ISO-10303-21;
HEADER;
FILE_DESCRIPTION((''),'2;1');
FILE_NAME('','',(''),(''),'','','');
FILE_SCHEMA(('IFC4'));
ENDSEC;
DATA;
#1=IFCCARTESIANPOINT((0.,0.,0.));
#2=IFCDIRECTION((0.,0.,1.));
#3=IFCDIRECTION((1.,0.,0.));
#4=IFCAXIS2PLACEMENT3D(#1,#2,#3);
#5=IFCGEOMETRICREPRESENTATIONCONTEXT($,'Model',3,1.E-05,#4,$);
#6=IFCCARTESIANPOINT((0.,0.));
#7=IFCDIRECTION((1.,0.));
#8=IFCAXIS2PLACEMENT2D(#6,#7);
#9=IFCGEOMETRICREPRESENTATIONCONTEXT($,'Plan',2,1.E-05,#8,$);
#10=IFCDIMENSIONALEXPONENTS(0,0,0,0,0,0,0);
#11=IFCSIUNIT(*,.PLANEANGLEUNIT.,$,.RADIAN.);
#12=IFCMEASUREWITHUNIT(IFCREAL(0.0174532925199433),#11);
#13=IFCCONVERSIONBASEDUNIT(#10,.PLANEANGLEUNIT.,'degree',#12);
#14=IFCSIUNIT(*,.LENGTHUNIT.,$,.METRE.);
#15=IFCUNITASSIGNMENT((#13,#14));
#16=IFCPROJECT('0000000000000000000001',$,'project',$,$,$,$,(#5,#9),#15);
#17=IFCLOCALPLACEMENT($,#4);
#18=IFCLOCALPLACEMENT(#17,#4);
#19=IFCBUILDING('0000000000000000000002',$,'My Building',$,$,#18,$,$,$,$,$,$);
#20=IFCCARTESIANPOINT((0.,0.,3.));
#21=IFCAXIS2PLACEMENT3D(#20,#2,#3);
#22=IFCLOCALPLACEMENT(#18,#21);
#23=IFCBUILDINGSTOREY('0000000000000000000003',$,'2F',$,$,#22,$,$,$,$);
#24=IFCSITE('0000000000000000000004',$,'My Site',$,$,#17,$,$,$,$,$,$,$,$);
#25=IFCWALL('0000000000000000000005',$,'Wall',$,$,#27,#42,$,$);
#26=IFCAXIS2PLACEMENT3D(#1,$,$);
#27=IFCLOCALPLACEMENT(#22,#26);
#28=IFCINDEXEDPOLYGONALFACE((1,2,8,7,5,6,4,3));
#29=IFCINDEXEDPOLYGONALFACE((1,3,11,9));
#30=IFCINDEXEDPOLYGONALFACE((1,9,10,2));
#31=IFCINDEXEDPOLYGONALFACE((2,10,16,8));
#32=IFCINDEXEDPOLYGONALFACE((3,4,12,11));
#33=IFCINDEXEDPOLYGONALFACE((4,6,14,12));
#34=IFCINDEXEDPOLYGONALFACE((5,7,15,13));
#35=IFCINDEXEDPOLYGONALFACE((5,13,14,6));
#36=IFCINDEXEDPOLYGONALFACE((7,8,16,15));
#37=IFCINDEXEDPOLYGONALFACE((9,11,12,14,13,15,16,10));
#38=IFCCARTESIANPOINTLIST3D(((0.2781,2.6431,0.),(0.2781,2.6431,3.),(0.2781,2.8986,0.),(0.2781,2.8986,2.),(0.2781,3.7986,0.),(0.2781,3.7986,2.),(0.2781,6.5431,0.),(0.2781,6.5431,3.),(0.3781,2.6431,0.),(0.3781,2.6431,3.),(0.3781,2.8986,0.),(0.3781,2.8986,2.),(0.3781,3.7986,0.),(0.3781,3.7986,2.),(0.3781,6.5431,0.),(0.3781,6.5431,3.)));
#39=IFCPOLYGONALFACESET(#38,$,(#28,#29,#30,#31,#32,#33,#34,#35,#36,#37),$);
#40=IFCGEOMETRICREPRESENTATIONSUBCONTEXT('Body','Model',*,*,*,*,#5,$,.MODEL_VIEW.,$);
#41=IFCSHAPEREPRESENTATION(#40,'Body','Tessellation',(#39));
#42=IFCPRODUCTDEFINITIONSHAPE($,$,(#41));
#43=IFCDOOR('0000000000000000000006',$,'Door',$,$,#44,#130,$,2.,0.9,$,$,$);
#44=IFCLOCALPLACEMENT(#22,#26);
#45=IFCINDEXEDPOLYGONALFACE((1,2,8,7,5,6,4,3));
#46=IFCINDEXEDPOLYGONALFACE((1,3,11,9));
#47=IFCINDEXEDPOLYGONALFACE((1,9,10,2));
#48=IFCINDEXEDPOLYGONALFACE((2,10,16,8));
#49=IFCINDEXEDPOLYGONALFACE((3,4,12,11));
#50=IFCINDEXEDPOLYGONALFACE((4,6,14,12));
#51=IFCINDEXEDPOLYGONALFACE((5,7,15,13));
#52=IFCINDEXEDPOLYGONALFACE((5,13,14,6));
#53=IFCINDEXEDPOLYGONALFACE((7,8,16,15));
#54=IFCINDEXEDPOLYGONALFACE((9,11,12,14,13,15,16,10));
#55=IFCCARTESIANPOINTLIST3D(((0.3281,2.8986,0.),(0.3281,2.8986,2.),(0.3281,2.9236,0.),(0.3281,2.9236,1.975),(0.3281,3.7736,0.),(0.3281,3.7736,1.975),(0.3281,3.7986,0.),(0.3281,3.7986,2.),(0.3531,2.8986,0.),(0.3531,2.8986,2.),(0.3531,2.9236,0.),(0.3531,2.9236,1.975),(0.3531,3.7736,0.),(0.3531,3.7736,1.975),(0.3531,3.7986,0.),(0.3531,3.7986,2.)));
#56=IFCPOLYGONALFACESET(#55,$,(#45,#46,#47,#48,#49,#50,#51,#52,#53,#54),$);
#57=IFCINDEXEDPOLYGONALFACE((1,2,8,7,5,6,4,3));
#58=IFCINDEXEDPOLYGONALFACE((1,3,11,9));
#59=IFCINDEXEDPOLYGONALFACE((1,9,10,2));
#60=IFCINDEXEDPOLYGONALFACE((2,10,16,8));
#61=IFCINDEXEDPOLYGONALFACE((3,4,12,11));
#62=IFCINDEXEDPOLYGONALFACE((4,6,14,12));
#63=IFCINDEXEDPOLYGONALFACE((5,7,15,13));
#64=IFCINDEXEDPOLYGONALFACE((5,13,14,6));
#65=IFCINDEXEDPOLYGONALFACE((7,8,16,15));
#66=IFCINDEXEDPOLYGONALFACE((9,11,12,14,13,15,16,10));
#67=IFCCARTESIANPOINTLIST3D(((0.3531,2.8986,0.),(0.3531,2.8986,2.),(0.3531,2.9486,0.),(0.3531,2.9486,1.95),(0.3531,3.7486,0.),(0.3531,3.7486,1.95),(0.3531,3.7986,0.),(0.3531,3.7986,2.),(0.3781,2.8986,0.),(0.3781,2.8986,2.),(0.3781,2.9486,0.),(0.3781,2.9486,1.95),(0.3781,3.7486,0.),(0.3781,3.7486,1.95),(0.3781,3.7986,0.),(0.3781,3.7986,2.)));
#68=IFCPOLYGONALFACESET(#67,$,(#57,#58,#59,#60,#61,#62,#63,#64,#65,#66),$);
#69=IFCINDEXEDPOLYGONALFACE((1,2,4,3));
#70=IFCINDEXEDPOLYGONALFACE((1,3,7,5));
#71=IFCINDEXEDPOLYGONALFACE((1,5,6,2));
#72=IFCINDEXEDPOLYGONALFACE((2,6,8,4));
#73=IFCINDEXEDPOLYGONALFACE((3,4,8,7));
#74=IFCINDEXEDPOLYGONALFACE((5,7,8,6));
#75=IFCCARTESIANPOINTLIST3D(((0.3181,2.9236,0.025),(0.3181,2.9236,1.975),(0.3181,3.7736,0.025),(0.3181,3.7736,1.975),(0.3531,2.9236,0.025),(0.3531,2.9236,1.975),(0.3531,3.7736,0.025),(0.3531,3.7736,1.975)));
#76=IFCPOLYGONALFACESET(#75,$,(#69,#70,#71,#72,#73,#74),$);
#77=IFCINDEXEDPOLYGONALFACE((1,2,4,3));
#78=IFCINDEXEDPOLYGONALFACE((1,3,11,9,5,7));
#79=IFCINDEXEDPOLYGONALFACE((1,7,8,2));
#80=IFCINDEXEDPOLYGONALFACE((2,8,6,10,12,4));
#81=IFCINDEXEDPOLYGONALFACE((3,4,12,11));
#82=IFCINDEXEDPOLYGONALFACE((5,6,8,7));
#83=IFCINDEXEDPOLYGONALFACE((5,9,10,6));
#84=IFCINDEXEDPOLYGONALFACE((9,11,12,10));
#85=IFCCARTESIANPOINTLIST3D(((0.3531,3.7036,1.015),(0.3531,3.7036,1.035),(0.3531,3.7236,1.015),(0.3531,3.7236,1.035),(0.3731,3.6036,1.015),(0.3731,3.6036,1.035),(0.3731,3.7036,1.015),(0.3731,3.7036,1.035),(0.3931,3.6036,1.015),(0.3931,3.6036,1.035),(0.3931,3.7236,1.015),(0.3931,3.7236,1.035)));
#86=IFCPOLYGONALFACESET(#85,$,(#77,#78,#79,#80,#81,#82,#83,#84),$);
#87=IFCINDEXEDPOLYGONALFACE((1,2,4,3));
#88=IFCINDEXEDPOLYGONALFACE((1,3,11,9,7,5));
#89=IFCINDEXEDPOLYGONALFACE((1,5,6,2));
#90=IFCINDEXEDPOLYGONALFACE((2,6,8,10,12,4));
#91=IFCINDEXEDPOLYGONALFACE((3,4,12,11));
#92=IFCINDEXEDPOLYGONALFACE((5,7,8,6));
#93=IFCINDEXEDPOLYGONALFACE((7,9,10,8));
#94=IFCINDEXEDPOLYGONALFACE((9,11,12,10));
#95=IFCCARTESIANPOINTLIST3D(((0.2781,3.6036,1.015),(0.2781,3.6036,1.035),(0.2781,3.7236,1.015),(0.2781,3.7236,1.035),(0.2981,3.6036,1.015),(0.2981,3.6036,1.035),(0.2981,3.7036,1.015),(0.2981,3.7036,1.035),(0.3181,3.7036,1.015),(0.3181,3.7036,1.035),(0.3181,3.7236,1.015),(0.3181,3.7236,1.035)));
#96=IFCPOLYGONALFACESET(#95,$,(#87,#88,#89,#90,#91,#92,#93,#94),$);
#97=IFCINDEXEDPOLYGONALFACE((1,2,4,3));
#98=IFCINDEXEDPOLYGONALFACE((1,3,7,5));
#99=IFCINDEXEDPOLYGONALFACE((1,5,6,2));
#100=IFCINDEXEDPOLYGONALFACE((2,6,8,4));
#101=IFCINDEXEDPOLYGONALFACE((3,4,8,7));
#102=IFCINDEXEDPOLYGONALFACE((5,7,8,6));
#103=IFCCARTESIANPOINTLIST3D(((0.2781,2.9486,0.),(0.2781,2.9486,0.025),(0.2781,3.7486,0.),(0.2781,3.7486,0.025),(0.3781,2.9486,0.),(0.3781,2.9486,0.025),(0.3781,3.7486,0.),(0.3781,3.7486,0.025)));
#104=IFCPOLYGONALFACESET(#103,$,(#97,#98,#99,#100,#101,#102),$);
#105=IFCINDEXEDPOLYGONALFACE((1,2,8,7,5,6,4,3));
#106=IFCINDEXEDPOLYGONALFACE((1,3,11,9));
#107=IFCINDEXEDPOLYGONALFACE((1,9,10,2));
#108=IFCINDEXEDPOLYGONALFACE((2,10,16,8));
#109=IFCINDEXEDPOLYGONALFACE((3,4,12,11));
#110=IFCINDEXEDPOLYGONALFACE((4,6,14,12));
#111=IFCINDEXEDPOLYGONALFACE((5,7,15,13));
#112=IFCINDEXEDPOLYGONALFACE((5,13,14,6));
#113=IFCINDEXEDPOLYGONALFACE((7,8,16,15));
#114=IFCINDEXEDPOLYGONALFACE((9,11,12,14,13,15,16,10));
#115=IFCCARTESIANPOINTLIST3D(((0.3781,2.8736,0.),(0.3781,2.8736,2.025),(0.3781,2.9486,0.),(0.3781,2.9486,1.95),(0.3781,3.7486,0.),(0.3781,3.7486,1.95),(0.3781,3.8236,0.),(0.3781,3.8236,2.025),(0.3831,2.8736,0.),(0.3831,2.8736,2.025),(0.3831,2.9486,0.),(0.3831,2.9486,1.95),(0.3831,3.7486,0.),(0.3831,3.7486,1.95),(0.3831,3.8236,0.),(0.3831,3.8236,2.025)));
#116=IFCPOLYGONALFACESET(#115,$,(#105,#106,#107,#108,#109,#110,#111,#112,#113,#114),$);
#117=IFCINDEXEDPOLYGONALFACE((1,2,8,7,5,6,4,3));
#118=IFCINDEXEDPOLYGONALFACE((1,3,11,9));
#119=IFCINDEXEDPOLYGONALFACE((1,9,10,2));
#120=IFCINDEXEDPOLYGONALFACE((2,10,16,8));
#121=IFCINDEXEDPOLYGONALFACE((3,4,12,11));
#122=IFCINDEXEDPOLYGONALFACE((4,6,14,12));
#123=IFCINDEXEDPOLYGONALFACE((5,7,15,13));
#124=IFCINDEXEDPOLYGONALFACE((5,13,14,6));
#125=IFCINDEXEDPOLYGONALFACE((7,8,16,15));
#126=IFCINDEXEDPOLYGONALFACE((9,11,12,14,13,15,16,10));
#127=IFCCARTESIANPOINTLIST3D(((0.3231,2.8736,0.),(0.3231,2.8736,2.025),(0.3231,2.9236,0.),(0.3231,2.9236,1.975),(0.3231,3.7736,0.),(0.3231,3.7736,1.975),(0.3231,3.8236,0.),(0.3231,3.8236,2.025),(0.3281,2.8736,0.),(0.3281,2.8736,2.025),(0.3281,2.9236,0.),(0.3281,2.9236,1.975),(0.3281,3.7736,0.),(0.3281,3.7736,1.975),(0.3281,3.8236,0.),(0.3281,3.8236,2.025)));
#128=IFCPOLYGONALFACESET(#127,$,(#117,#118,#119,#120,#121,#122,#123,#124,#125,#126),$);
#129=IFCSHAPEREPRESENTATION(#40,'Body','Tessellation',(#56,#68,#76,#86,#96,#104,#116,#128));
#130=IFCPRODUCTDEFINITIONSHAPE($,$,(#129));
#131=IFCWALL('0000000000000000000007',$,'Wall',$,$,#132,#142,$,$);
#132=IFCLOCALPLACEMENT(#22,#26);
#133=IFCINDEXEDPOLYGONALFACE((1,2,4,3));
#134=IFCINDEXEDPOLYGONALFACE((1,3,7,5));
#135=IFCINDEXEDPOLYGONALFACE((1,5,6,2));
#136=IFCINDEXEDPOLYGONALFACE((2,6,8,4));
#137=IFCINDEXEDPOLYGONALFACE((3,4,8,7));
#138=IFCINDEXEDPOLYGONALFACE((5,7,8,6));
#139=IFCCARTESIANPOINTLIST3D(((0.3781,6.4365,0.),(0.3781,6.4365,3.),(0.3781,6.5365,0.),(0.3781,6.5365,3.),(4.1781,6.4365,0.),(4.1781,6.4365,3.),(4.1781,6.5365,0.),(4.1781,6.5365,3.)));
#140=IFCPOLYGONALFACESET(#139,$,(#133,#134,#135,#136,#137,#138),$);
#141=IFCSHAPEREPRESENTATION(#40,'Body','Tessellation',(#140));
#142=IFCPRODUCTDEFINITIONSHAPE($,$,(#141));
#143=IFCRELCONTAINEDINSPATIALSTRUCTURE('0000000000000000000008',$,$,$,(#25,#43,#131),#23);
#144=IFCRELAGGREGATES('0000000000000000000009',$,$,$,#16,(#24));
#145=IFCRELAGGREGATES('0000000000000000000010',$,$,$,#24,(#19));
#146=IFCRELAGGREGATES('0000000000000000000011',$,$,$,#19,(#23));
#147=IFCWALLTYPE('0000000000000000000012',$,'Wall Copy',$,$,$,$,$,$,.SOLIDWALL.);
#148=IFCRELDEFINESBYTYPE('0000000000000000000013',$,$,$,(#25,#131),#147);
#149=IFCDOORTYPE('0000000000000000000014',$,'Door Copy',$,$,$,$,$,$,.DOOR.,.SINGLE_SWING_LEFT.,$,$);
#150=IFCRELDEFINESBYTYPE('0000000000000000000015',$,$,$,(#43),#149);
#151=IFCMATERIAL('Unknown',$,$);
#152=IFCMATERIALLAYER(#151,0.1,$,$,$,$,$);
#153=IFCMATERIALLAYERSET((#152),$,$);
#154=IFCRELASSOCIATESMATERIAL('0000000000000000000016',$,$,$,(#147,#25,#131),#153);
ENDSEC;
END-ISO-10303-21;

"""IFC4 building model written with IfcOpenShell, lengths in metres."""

from ifc_helpers import new_model, entity, si_unit, converted_unit, frame, origin_with_axes, origin_2d_with_axis, place, context, subcontext, project, spatial, line, indexed_curve, outline, extrude, shape, source, transform, mapped, material, layer, layer_set, layer_usage, type_object, type_shapes, element, fill, save


model = new_model("IFC4")

# Units and contexts
model_context = context("Model", 3, precision=1e-05, world=origin_with_axes())
plan_context = context("Plan", 2, precision=1e-05, world=origin_2d_with_axis())
body_context_1 = subcontext(model_context, "Body", "Model", "MODEL_VIEW")
body_context_2 = subcontext(plan_context, "Body", "Plan", "PLAN_VIEW")
ifc_project = project(units=[converted_unit("PLANEANGLEUNIT", "degree", entity("IfcReal", 0.0174532925199433), si_unit("PLANEANGLEUNIT", "RADIAN"), dimensions=[0, 0, 0, 0, 0, 0, 0]), si_unit("LENGTHUNIT", "METRE")], contexts=[model_context, plan_context])

# Site, building, storey
site_placement = place(None, origin_with_axes())
site = spatial("IfcSite", under=ifc_project, at=site_placement, Name="My Site")
building_placement = place(site_placement, origin_with_axes())
building = spatial("IfcBuilding", under=site, at=building_placement, Name="My Building")
storey_placement = place(building_placement, frame((0.0, 0.0, 3.0), z_axis=(0.0, 0.0, 1.0), x_axis=(1.0, 0.0, 0.0)))
storey = spatial("IfcBuildingStorey", under=building, at=storey_placement, Name="2F")

# Shared definitions
ifc_material = material(Name="Unknown")
ifc_layer_1 = layer(ifc_material, 0.1)
ifc_layer_set_1 = layer_set([ifc_layer_1])
wall_type_1 = type_object("IfcWallType", Name="Wall Copy", PredefinedType="SOLIDWALL", material=ifc_layer_set_1)

# Wall, opening, door
shared_shape_1 = source(origin_with_axes(), body_context_1, "Body", "SweptSolid", [
    extrude(outline(indexed_curve([(0.0, 0.0), (0.9, 0.0), (0.9, 2.0), (0.0, 2.0)], segments=[line(1, 2, 3, 4, 1)])), frame((0.0, -0.6, 0.0), z_axis=(0.0, -1.0, 0.0), x_axis=(1.0, 0.0, 0.0)), (0.0, 0.0, -1.0), 1.2),
])
door_type = type_object("IfcDoorType", Name="Door Copy", OperationType="SINGLE_SWING_LEFT", PredefinedType="DOOR")
shared_shape_2 = source(origin_with_axes(), body_context_1, "Body", "SweptSolid", [
    extrude(outline(indexed_curve([(0.0, 0.0), (0.0, 2.0), (0.9, 2.0), (0.9, 0.0), (0.875, 0.0), (0.875, 1.975), (0.025, 1.975), (0.025, 0.0)], segments=[line(1, 2, 3, 4, 5, 6, 7, 8, 1)])), frame((0.0, 0.025, 0.0), z_axis=(0.0, -1.0, 0.0), x_axis=(1.0, 0.0, 0.0)), (0.0, 0.0, -1.0), 0.025),
    extrude(outline(indexed_curve([(0.0, 0.0), (0.0, 2.0), (0.9, 2.0), (0.9, 0.0), (0.85, 0.0), (0.85, 1.95), (0.05, 1.95), (0.05, 0.0)], segments=[line(1, 2, 3, 4, 5, 6, 7, 8, 1)])), frame((0.0, 0.0, 0.0), z_axis=(0.0, -1.0, 0.0), x_axis=(1.0, 0.0, 0.0)), (0.0, 0.0, -1.0), 0.025),
    extrude(outline(indexed_curve([(0.0, 0.0), (0.85, 0.0), (0.85, 0.035), (0.0, 0.035)], segments=[line(1, 2, 3, 4, 1)])), frame((0.025, 0.025, 0.025), z_axis=(0.0, 0.0, 1.0), x_axis=(1.0, 0.0, 0.0)), (0.0, 0.0, 1.0), 1.95),
    extrude(outline(indexed_curve([(0.0, 0.0), (0.0, -0.04), (-0.12, -0.04), (-0.12, -0.02), (-0.02, -0.02), (-0.02, 0.0)], segments=[line(1, 2, 3, 4, 5, 6, 1)])), frame((0.825, 0.025, 1.015), z_axis=(0.0, 0.0, 1.0), x_axis=(1.0, 0.0, 0.0)), (0.0, 0.0, 1.0), 0.02),
    extrude(outline(indexed_curve([(0.0, 0.0), (0.0, 0.04), (-0.12, 0.04), (-0.12, 0.02), (-0.02, 0.02), (-0.02, 0.0)], segments=[line(1, 2, 3, 4, 5, 6, 1)])), frame((0.825, 0.06, 1.015), z_axis=(0.0, 0.0, 1.0), x_axis=(1.0, 0.0, 0.0)), (0.0, 0.0, 1.0), 0.02),
    extrude(outline(indexed_curve([(0.0, 0.0), (0.8, 0.0), (0.8, 0.1), (0.0, 0.1)], segments=[line(1, 2, 3, 4, 1)])), frame((0.05, 0.0, 0.0), z_axis=(0.0, 0.0, 1.0), x_axis=(1.0, 0.0, 0.0)), (0.0, 0.0, 1.0), 0.025),
    extrude(outline(indexed_curve([(0.0, 0.0), (0.0, 2.025), (0.95, 2.025), (0.95, 0.0), (0.875, 0.0), (0.875, 1.95), (0.075, 1.95), (0.075, 0.0)], segments=[line(1, 2, 3, 4, 5, 6, 7, 8, 1)])), frame((-0.025, -0.005, 0.0), z_axis=(0.0, -1.0, 0.0), x_axis=(1.0, 0.0, 0.0)), (0.0, 0.0, -1.0), 0.005),
    extrude(outline(indexed_curve([(0.0, 0.0), (0.0, 2.025), (0.95, 2.025), (0.95, 0.0), (0.9, 0.0), (0.9, 1.975), (0.05, 1.975), (0.05, 0.0)], segments=[line(1, 2, 3, 4, 5, 6, 7, 8, 1)])), frame((-0.025, 0.05, 0.0), z_axis=(0.0, -1.0, 0.0), x_axis=(1.0, 0.0, 0.0)), (0.0, 0.0, -1.0), 0.005),
])
shared_shape_3 = source(origin_with_axes(), body_context_2, "Body", "Curve2D", [
    entity("IfcIndexedPolyCurve", entity("IfcCartesianPointList2D", [[0.0, 0.0], [0.0, 0.05], [0.025, 0.05], [0.025, 0.025], [0.05, 0.025], [0.05, 0.0]]), [entity("IfcLineIndex", [1, 2, 3, 4, 5, 6, 1])]),
    entity("IfcIndexedPolyCurve", entity("IfcCartesianPointList2D", [[0.9, 0.0], [0.9, 0.05], [0.875, 0.05], [0.875, 0.025], [0.85, 0.025], [0.85, 0.0]]), [entity("IfcLineIndex", [1, 2, 3, 4, 5, 6, 1])]),
    entity("IfcTrimmedCurve", entity("IfcEllipse", entity("IfcAxis2Placement2D", entity("IfcCartesianPoint", [0.06, 0.05]), entity("IfcDirection", [1.0, 0.0])), 0.815, 0.85), [entity("IfcCartesianPoint", [0.875, 0.05])], [entity("IfcCartesianPoint", [0.06, 0.9])], True, "CARTESIAN"),
    entity("IfcIndexedPolyCurve", entity("IfcCartesianPointList2D", [[0.025, 0.05], [0.06, 0.05], [0.06, 0.9], [0.025, 0.9]]), [entity("IfcLineIndex", [1, 2, 3, 4, 1])]),
])
type_shapes(door_type, [shared_shape_2, shared_shape_3])
ifc_layer_usage_1 = layer_usage(ifc_layer_set_1, "AXIS2", "POSITIVE", 0.0)
wall_1_placement = place(storey_placement, frame((0.3781, 2.6431, 0.0), z_axis=(0.0, 0.0, 1.0), x_axis=(0.0, 1.0, 0.0)))
wall_1 = element("IfcWall", 1, at=wall_1_placement, inside=storey, type_object=wall_type_1, material=ifc_layer_usage_1, Name="Wall", context=body_context_1, shape_type="SweptSolid", body=[
    extrude(outline(indexed_curve([(0.0, 0.0), (0.0, 0.1), (3.9, 0.1), (3.9, 0.0)], segments=[line(1, 2, 3, 4, 1)])), origin_with_axes(), (0.0, 0.0, 1.0), 3.0),
])
opening_1_placement = place(wall_1_placement, frame((0.2554, 0.0, 0.0), z_axis=(0.0, 0.0, 1.0), x_axis=(1.0, 0.0, 0.0)))
opening_1 = element("IfcOpeningElement", 2, at=opening_1_placement, cuts=wall_1, PredefinedType="OPENING", context=body_context_1, shape_type="MappedRepresentation", body=[
    mapped(shared_shape_1, transform((0.0, 0.0, 0.0), x_axis=(1.0, 0.0, 0.0), y_axis=(0.0, 1.0, 0.0), z_axis=(0.0, 0.0, 1.0), scale=1.0)),
])
door_1_placement = place(opening_1_placement, frame((0.0, 0.0, 0.0), z_axis=(0.0, 0.0, 1.0), x_axis=(1.0, 0.0, 0.0)))
door_1 = element("IfcDoor", 3, at=door_1_placement, inside=storey, type_object=door_type, Name="Door", OverallHeight=2.0, OverallWidth=0.9, shapes=[
    shape(body_context_1, "Body", "MappedRepresentation", [mapped(shared_shape_2, transform((0.0, 0.0, 0.0), x_axis=(1.0, 0.0, 0.0), y_axis=(0.0, 1.0, 0.0), z_axis=(0.0, 0.0, 1.0), scale=1.0))]),
    shape(body_context_2, "Body", "MappedRepresentation", [mapped(shared_shape_3, transform((0.0, 0.0, 0.0), x_axis=(1.0, 0.0, 0.0), y_axis=(0.0, 1.0, 0.0), z_axis=(0.0, 0.0, 1.0), scale=1.0))]),
])
fill(opening_1, door_1)

# Wall
ifc_layer_usage_2 = layer_usage(ifc_layer_set_1, "AXIS2", "POSITIVE", 0.0)
wall_2_placement = place(storey_placement, frame((0.3781, 6.4365, 0.0), z_axis=(0.0, 0.0, 1.0), x_axis=(1.0, 0.0, 0.0)))
element("IfcWall", 4, at=wall_2_placement, inside=storey, type_object=wall_type_1, material=ifc_layer_usage_2, Name="Wall", context=body_context_1, shape_type="SweptSolid", body=[
    extrude(outline(indexed_curve([(0.0, 0.0), (0.0, 0.1), (3.8, 0.1), (3.8, 0.0)], segments=[line(1, 2, 3, 4, 1)])), origin_with_axes(), (0.0, 0.0, 1.0), 3.0),
])

save(model, "model.ifc")
